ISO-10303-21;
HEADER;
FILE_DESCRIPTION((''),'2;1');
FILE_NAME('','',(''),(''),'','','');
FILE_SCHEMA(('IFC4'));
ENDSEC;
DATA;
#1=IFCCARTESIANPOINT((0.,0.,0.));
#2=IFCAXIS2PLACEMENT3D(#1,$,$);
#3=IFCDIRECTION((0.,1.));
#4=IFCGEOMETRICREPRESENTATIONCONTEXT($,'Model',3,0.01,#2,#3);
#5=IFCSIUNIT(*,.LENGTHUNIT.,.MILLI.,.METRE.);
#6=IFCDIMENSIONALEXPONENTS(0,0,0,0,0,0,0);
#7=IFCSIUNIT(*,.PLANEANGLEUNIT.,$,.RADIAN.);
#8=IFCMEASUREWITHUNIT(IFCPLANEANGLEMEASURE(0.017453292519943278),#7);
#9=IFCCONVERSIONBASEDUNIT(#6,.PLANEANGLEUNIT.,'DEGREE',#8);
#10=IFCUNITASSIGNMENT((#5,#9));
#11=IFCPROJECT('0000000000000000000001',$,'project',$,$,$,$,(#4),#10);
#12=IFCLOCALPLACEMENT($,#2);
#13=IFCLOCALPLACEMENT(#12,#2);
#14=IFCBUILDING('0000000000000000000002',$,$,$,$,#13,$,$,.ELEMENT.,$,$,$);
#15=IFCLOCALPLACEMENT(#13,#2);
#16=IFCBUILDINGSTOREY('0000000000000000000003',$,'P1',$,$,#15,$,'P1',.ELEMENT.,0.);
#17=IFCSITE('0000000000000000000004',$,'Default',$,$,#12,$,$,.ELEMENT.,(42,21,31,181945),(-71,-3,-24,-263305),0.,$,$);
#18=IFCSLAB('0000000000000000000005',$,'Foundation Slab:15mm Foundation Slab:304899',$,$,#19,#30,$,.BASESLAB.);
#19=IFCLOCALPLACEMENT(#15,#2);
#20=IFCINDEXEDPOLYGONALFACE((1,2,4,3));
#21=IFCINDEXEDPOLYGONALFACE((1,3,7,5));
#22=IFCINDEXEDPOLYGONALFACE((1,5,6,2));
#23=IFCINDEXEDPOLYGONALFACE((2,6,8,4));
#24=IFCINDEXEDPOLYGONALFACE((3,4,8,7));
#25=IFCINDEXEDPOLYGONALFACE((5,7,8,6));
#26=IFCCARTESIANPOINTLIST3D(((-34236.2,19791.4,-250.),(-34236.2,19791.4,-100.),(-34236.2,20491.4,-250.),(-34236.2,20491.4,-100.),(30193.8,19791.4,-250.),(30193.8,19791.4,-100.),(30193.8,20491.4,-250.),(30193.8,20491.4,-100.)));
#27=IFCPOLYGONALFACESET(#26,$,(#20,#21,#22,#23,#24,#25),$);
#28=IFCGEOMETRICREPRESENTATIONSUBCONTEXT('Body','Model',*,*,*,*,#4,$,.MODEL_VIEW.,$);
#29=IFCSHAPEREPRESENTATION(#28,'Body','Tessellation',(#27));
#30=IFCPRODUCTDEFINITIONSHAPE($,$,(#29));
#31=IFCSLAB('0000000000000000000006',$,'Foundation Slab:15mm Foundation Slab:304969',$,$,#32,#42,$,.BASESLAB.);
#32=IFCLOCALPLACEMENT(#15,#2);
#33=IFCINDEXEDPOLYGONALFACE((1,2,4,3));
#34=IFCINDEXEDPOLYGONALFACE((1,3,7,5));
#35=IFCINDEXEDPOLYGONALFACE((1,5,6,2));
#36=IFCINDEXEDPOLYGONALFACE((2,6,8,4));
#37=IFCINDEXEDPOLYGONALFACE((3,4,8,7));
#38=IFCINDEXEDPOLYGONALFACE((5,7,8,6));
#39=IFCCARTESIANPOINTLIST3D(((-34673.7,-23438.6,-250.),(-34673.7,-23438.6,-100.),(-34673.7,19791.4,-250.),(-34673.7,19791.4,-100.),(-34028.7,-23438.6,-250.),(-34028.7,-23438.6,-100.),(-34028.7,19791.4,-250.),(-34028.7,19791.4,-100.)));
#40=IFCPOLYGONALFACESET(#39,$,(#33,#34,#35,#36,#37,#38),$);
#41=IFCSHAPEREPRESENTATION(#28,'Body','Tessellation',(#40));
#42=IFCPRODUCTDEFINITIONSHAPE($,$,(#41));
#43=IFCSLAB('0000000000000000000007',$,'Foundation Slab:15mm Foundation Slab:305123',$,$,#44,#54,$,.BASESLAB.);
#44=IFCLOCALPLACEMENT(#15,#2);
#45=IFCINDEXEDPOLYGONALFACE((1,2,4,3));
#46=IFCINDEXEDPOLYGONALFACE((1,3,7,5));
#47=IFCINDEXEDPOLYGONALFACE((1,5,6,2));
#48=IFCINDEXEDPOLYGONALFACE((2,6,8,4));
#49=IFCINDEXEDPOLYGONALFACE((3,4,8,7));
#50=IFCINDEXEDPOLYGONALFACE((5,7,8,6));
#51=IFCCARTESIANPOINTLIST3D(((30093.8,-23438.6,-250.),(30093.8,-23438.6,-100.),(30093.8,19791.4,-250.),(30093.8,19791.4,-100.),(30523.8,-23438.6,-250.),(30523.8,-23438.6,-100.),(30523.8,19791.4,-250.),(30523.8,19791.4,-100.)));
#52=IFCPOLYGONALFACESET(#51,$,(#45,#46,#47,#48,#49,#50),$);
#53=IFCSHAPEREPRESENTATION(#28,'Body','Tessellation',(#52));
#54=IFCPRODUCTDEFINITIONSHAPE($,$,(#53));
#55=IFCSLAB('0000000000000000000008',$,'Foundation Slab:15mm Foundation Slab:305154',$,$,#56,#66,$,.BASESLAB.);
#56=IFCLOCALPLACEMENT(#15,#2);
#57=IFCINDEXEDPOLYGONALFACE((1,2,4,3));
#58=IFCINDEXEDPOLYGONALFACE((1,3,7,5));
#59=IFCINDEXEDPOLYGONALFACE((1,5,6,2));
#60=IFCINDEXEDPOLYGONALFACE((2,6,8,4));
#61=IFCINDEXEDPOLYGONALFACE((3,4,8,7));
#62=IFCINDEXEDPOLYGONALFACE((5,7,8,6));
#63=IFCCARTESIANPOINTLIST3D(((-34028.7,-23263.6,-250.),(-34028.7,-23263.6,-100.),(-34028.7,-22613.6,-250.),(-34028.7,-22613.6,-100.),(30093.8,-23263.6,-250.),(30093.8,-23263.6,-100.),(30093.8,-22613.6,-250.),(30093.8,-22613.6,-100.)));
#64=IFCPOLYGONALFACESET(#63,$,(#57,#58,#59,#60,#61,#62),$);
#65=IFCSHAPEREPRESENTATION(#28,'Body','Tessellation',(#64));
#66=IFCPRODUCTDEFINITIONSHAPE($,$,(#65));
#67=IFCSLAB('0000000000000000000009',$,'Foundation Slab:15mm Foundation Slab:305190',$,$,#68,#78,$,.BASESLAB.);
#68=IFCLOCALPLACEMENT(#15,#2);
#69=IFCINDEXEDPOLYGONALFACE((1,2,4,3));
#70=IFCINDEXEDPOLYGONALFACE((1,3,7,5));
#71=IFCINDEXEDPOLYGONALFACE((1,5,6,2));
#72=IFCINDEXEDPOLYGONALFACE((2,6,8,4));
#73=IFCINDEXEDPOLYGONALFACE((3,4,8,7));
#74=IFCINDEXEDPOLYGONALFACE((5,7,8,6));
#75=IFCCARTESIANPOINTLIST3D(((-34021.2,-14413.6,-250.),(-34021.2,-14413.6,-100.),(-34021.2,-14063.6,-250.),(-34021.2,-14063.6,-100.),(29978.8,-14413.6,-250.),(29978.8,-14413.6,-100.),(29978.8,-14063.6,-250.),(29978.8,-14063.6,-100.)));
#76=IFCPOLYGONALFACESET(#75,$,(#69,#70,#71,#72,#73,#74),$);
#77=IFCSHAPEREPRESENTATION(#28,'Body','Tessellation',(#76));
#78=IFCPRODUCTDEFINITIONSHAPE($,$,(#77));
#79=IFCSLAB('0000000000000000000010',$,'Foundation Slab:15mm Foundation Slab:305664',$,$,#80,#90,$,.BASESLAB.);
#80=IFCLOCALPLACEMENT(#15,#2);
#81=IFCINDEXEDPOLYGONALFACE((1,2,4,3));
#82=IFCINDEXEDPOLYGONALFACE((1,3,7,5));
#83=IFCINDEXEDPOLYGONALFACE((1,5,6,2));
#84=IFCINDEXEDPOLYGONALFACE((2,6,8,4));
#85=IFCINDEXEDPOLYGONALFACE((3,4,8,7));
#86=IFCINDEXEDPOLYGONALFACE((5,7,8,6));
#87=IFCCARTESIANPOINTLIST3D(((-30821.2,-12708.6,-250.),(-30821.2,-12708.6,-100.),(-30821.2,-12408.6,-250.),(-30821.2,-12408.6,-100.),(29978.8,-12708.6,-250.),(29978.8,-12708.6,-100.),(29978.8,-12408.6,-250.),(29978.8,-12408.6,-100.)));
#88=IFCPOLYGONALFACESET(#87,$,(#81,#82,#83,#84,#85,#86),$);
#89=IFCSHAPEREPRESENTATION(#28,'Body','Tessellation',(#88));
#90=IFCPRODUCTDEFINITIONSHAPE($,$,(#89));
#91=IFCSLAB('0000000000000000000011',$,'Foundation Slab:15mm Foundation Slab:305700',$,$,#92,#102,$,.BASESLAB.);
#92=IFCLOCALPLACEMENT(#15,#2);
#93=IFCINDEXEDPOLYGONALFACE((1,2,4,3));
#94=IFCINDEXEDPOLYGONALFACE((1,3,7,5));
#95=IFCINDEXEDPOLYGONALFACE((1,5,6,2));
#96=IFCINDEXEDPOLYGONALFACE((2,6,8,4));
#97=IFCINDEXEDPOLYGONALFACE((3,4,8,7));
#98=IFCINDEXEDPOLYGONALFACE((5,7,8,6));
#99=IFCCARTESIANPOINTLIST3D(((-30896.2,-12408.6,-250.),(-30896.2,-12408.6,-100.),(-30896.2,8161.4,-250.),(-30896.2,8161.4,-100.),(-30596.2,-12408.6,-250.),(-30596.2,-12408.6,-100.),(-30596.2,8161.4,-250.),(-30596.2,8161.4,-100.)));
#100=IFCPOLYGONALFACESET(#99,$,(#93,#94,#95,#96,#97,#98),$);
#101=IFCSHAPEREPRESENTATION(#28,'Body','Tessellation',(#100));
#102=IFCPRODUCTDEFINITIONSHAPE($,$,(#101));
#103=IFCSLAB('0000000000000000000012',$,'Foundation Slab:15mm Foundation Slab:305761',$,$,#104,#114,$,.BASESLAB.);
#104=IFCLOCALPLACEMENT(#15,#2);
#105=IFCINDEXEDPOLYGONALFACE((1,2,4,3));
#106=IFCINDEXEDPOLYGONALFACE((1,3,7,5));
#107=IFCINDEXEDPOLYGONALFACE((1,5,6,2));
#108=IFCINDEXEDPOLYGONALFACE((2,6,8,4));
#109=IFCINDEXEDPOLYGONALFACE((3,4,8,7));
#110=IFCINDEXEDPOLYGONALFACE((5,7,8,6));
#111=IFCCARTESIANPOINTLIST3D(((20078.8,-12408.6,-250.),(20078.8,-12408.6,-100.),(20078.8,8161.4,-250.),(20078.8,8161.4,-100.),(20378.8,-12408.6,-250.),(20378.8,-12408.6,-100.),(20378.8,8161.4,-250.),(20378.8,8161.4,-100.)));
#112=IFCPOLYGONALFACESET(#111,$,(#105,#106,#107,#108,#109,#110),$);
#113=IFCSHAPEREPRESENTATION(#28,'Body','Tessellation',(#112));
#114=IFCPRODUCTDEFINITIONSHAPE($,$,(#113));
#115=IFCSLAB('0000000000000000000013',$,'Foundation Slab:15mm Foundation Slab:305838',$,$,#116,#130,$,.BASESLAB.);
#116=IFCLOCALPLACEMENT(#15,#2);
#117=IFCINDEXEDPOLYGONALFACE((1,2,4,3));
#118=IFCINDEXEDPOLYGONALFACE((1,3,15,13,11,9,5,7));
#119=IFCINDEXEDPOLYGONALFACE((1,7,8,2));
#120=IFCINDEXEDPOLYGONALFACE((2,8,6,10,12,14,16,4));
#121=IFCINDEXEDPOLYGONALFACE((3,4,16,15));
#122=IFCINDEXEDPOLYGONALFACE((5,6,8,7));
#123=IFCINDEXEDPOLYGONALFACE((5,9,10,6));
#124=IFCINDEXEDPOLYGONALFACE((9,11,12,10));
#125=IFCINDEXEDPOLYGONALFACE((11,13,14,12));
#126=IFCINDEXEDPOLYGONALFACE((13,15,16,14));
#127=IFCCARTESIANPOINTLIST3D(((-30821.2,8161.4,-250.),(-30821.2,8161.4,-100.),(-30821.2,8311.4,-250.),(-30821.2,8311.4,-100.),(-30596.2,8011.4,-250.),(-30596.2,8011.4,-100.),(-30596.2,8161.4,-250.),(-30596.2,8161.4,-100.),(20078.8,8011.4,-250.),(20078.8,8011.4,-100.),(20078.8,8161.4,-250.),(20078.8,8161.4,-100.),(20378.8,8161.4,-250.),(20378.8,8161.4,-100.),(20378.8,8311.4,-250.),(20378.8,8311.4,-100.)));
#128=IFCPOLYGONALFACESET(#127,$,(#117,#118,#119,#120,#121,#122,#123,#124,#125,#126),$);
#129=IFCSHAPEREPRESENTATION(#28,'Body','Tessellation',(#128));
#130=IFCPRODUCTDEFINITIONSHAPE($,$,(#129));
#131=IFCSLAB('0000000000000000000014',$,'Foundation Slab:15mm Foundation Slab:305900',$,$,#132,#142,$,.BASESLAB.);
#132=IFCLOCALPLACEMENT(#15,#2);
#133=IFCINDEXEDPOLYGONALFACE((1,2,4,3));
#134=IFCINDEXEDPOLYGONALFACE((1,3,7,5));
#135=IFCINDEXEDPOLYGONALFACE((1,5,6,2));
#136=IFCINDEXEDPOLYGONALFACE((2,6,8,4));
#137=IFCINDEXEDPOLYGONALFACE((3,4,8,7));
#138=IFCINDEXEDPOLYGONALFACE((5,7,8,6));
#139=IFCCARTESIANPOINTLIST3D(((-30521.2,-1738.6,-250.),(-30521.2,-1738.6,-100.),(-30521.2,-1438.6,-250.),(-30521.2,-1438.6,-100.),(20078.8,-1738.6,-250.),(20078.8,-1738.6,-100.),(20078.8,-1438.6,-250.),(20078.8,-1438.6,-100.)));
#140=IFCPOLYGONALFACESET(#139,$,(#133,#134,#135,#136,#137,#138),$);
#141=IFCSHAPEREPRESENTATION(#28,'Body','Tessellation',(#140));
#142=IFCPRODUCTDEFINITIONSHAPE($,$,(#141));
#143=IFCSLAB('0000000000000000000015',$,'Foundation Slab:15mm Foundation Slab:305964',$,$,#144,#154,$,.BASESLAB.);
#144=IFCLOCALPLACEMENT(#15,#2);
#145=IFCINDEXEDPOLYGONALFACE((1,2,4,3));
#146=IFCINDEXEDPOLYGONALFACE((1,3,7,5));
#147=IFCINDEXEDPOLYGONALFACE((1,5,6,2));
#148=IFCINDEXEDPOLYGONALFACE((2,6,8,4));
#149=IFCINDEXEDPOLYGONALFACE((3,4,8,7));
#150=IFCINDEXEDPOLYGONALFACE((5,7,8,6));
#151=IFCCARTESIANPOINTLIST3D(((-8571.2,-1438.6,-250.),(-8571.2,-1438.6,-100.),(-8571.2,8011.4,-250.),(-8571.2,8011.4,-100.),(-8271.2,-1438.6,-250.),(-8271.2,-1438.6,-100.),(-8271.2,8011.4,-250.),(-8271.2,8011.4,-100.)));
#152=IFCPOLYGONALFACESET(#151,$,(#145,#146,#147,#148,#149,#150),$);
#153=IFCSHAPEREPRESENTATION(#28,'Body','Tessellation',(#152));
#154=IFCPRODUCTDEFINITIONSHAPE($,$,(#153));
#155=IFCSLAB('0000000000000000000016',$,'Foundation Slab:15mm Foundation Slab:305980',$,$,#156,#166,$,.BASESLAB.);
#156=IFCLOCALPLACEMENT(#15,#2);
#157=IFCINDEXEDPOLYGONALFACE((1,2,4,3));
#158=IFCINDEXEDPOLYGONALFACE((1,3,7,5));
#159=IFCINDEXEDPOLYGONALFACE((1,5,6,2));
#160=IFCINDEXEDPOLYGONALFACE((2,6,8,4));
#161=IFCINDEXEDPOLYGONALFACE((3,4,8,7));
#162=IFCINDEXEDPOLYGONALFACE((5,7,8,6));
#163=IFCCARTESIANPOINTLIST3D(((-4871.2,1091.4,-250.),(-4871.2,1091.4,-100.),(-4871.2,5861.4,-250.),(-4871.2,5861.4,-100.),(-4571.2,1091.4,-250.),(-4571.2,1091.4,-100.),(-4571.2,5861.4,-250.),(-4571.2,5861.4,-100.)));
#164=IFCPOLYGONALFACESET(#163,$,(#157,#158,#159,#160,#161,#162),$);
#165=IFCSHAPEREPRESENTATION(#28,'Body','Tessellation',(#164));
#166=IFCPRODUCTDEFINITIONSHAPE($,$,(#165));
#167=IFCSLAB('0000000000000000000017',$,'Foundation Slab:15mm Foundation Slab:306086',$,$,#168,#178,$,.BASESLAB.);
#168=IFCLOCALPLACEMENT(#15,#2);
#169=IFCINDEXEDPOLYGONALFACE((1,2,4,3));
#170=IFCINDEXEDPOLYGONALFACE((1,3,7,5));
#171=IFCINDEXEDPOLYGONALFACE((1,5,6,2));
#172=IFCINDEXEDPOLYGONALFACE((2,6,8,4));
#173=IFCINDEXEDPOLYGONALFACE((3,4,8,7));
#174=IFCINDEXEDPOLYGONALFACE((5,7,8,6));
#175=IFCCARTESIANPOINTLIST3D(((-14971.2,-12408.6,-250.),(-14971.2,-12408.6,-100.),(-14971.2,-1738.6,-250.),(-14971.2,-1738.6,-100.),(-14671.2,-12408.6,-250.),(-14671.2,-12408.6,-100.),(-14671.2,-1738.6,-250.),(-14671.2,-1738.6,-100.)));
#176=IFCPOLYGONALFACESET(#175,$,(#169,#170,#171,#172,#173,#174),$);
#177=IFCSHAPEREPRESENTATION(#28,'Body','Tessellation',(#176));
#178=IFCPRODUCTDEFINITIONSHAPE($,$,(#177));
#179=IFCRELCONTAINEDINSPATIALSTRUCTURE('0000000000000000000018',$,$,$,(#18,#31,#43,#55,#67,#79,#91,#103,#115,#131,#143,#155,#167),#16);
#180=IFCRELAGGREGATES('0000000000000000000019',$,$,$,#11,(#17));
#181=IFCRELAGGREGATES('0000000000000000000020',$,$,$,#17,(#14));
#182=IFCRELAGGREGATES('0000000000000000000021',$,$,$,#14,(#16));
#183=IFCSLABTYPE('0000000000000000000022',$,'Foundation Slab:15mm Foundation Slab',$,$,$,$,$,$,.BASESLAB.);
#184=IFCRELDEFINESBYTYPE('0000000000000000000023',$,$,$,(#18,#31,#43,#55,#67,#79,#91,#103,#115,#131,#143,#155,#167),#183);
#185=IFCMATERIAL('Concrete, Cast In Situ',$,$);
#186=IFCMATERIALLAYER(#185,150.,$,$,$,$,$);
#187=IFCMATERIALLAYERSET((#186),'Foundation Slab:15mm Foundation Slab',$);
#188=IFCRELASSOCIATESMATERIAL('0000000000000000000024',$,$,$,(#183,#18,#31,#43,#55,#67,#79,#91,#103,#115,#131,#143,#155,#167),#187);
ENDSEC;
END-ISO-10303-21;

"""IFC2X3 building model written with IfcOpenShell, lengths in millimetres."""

from ifc_helpers import new_model, entity, si_unit, converted_unit, direction, frame, frame_2d, origin, origin_2d_with_axis, place, context, subcontext, project, spatial, polyline, rectangle, outline, extrude, material, layer, layer_set, layer_usage, type_object, element, save


model = new_model("IFC2X3")

# Units and contexts
model_context = context("Model", 3, precision=0.01, world=origin(), true_north=direction((0.0, 1.0)))
body_context = subcontext(model_context, "Body", "Model", "MODEL_VIEW")
ifc_project = project(units=[si_unit("LENGTHUNIT", "METRE", prefix="MILLI"), converted_unit("PLANEANGLEUNIT", "DEGREE", entity("IfcPlaneAngleMeasure", 0.017453292519943278), si_unit("PLANEANGLEUNIT", "RADIAN"), dimensions=[0, 0, 0, 0, 0, 0, 0])], contexts=[model_context])

# Site, building, storey
site_placement = place(None, origin())
site = spatial("IfcSite", under=ifc_project, at=site_placement, Name="Default", CompositionType="ELEMENT", RefLatitude=(42, 21, 31, 181945), RefLongitude=(-71, -3, -24, -263305), RefElevation=0.0)
building_placement = place(site_placement, origin())
building = spatial("IfcBuilding", under=site, at=building_placement, CompositionType="ELEMENT")
storey_placement = place(building_placement, origin())
storey = spatial("IfcBuildingStorey", under=building, at=storey_placement, Name="P1", LongName="P1", CompositionType="ELEMENT", Elevation=0.0)

# Slabs
ifc_material_1 = material(Name="Concrete, Cast In Situ")
ifc_layer = layer(ifc_material_1, 150.0)
ifc_layer_set = layer_set([ifc_layer], Name="Foundation Slab:15mm Foundation Slab")
ifc_layer_usage_1 = layer_usage(ifc_layer_set, "AXIS3", "POSITIVE", 0.0)
slab_type = type_object("IfcSlabType", Name="Foundation Slab:15mm Foundation Slab", PredefinedType="BASESLAB", material=ifc_layer_set)
slab_1_placement = place(storey_placement, origin())
element("IfcSlab", 1, at=slab_1_placement, inside=storey, type_object=slab_type, material=ifc_layer_usage_1, Name="Foundation Slab:15mm Foundation Slab:304899", PredefinedType="BASESLAB", context=body_context, shape_type="SweptSolid", body=[
    extrude(rectangle(XDim=700.0, YDim=64430.0, at=frame_2d((0.0, 0.0), x_axis=(1.0, 0.0))), frame((-2021.2, 20141.4, -100.0), z_axis=(0.0, 0.0, -1.0), x_axis=(0.0, 1.0, 0.0)), (0.0, 0.0, 1.0), 150.0),
])
ifc_layer_usage_2 = layer_usage(ifc_layer_set, "AXIS3", "POSITIVE", 0.0)
slab_2_placement = place(storey_placement, origin())
element("IfcSlab", 2, at=slab_2_placement, inside=storey, type_object=slab_type, material=ifc_layer_usage_2, Name="Foundation Slab:15mm Foundation Slab:304969", PredefinedType="BASESLAB", context=body_context, shape_type="SweptSolid", body=[
    extrude(rectangle(XDim=43230.0, YDim=645.0, at=origin_2d_with_axis()), frame((-34351.2, -1823.6, -100.0), z_axis=(0.0, 0.0, -1.0), x_axis=(0.0, 1.0, 0.0)), (0.0, 0.0, 1.0), 150.0),
])
ifc_layer_usage_3 = layer_usage(ifc_layer_set, "AXIS3", "POSITIVE", 0.0)
slab_3_placement = place(storey_placement, origin())
element("IfcSlab", 3, at=slab_3_placement, inside=storey, type_object=slab_type, material=ifc_layer_usage_3, Name="Foundation Slab:15mm Foundation Slab:305123", PredefinedType="BASESLAB", context=body_context, shape_type="SweptSolid", body=[
    extrude(rectangle(XDim=43230.0, YDim=430.0, at=frame_2d((0.0, 0.0), x_axis=(1.0, 0.0))), frame((30308.8, -1823.6, -100.0), z_axis=(0.0, 0.0, -1.0), x_axis=(0.0, 1.0, 0.0)), (0.0, 0.0, 1.0), 150.0),
])
ifc_layer_usage_4 = layer_usage(ifc_layer_set, "AXIS3", "POSITIVE", 0.0)
slab_4_placement = place(storey_placement, origin())
element("IfcSlab", 4, at=slab_4_placement, inside=storey, type_object=slab_type, material=ifc_layer_usage_4, Name="Foundation Slab:15mm Foundation Slab:305154", PredefinedType="BASESLAB", context=body_context, shape_type="SweptSolid", body=[
    extrude(rectangle(XDim=650.0, YDim=64122.5, at=frame_2d((0.0, 0.0), x_axis=(1.0, 0.0))), frame((-1967.5, -22938.6, -100.0), z_axis=(0.0, 0.0, -1.0), x_axis=(0.0, 1.0, 0.0)), (0.0, 0.0, 1.0), 150.0),
])
ifc_layer_usage_5 = layer_usage(ifc_layer_set, "AXIS3", "POSITIVE", 0.0)
slab_5_placement = place(storey_placement, origin())
element("IfcSlab", 5, at=slab_5_placement, inside=storey, type_object=slab_type, material=ifc_layer_usage_5, Name="Foundation Slab:15mm Foundation Slab:305190", PredefinedType="BASESLAB", context=body_context, shape_type="SweptSolid", body=[
    extrude(rectangle(XDim=350.0, YDim=64000.0, at=frame_2d((0.0, 0.0), x_axis=(1.0, 0.0))), frame((-2021.2, -14238.6, -100.0), z_axis=(0.0, 0.0, -1.0), x_axis=(0.0, 1.0, 0.0)), (0.0, 0.0, 1.0), 150.0),
])
ifc_layer_usage_6 = layer_usage(ifc_layer_set, "AXIS3", "POSITIVE", 0.0)
slab_6_placement = place(storey_placement, origin())
element("IfcSlab", 6, at=slab_6_placement, inside=storey, type_object=slab_type, material=ifc_layer_usage_6, Name="Foundation Slab:15mm Foundation Slab:305664", PredefinedType="BASESLAB", context=body_context, shape_type="SweptSolid", body=[
    extrude(rectangle(XDim=300.0, YDim=60800.0, at=frame_2d((0.0, 0.0), x_axis=(1.0, 0.0))), frame((-421.2, -12558.6, -100.0), z_axis=(0.0, 0.0, -1.0), x_axis=(0.0, 1.0, 0.0)), (0.0, 0.0, 1.0), 150.0),
])
ifc_layer_usage_7 = layer_usage(ifc_layer_set, "AXIS3", "POSITIVE", 0.0)
slab_7_placement = place(storey_placement, origin())
element("IfcSlab", 7, at=slab_7_placement, inside=storey, type_object=slab_type, material=ifc_layer_usage_7, Name="Foundation Slab:15mm Foundation Slab:305700", PredefinedType="BASESLAB", context=body_context, shape_type="SweptSolid", body=[
    extrude(rectangle(XDim=20570.0, YDim=300.0, at=frame_2d((0.0, 0.0), x_axis=(1.0, 0.0))), frame((-30746.2, -2123.6, -100.0), z_axis=(0.0, 0.0, -1.0), x_axis=(0.0, 1.0, 0.0)), (0.0, 0.0, 1.0), 150.0),
])
ifc_layer_usage_8 = layer_usage(ifc_layer_set, "AXIS3", "POSITIVE", 0.0)
slab_8_placement = place(storey_placement, origin())
element("IfcSlab", 8, at=slab_8_placement, inside=storey, type_object=slab_type, material=ifc_layer_usage_8, Name="Foundation Slab:15mm Foundation Slab:305761", PredefinedType="BASESLAB", context=body_context, shape_type="SweptSolid", body=[
    extrude(rectangle(XDim=20570.0, YDim=300.0, at=frame_2d((0.0, 0.0), x_axis=(1.0, 0.0))), frame((20228.8, -2123.6, -100.0), z_axis=(0.0, 0.0, -1.0), x_axis=(0.0, 1.0, 0.0)), (0.0, 0.0, 1.0), 150.0),
])
ifc_layer_usage_9 = layer_usage(ifc_layer_set, "AXIS3", "POSITIVE", 0.0)
slab_9_placement = place(storey_placement, origin())
element("IfcSlab", 9, at=slab_9_placement, inside=storey, type_object=slab_type, material=ifc_layer_usage_9, Name="Foundation Slab:15mm Foundation Slab:305838", PredefinedType="BASESLAB", context=body_context, shape_type="SweptSolid", body=[
    extrude(outline(polyline([(0.0, -25581.3), (150.0, -25581.3), (150.0, 25618.8), (0.0, 25618.8), (0.0, 25318.8), (-150.0, 25318.8), (-150.0, -25356.3), (0.0, -25356.3), (0.0, -25581.3)])), frame((-5240.0, 8161.4, -100.0), z_axis=(0.0, 0.0, -1.0), x_axis=(0.0, 1.0, 0.0)), (0.0, 0.0, 1.0), 150.0),
])
ifc_layer_usage_10 = layer_usage(ifc_layer_set, "AXIS3", "POSITIVE", 0.0)
slab_10_placement = place(storey_placement, origin())
element("IfcSlab", 10, at=slab_10_placement, inside=storey, type_object=slab_type, material=ifc_layer_usage_10, Name="Foundation Slab:15mm Foundation Slab:305900", PredefinedType="BASESLAB", context=body_context, shape_type="SweptSolid", body=[
    extrude(rectangle(XDim=300.0, YDim=50600.0, at=origin_2d_with_axis()), frame((-5221.2, -1588.6, -100.0), z_axis=(0.0, 0.0, -1.0), x_axis=(0.0, 1.0, 0.0)), (0.0, 0.0, 1.0), 150.0),
])
ifc_layer_usage_11 = layer_usage(ifc_layer_set, "AXIS3", "POSITIVE", 0.0)
slab_11_placement = place(storey_placement, origin())
element("IfcSlab", 11, at=slab_11_placement, inside=storey, type_object=slab_type, material=ifc_layer_usage_11, Name="Foundation Slab:15mm Foundation Slab:305964", PredefinedType="BASESLAB", context=body_context, shape_type="SweptSolid", body=[
    extrude(rectangle(XDim=9450.0, YDim=300.0, at=frame_2d((0.0, 0.0), x_axis=(1.0, 0.0))), frame((-8421.2, 3286.4, -100.0), z_axis=(0.0, 0.0, -1.0), x_axis=(0.0, 1.0, 0.0)), (0.0, 0.0, 1.0), 150.0),
])
ifc_layer_usage_12 = layer_usage(ifc_layer_set, "AXIS3", "POSITIVE", 0.0)
slab_12_placement = place(storey_placement, origin())
element("IfcSlab", 12, at=slab_12_placement, inside=storey, type_object=slab_type, material=ifc_layer_usage_12, Name="Foundation Slab:15mm Foundation Slab:305980", PredefinedType="BASESLAB", context=body_context, shape_type="SweptSolid", body=[
    extrude(rectangle(XDim=4770.0, YDim=300.0, at=origin_2d_with_axis()), frame((-4721.2, 3476.4, -100.0), z_axis=(0.0, 0.0, -1.0), x_axis=(0.0, 1.0, 0.0)), (0.0, 0.0, 1.0), 150.0),
])
ifc_layer_usage_13 = layer_usage(ifc_layer_set, "AXIS3", "POSITIVE", 0.0)
slab_13_placement = place(storey_placement, origin())
element("IfcSlab", 13, at=slab_13_placement, inside=storey, type_object=slab_type, material=ifc_layer_usage_13, Name="Foundation Slab:15mm Foundation Slab:306086", PredefinedType="BASESLAB", context=body_context, shape_type="SweptSolid", body=[
    extrude(rectangle(XDim=10670.0, YDim=300.0, at=origin_2d_with_axis()), frame((-14821.2, -7073.6, -100.0), z_axis=(0.0, 0.0, -1.0), x_axis=(0.0, 1.0, 0.0)), (0.0, 0.0, 1.0), 150.0),
])

save(model, "model.ifc")
